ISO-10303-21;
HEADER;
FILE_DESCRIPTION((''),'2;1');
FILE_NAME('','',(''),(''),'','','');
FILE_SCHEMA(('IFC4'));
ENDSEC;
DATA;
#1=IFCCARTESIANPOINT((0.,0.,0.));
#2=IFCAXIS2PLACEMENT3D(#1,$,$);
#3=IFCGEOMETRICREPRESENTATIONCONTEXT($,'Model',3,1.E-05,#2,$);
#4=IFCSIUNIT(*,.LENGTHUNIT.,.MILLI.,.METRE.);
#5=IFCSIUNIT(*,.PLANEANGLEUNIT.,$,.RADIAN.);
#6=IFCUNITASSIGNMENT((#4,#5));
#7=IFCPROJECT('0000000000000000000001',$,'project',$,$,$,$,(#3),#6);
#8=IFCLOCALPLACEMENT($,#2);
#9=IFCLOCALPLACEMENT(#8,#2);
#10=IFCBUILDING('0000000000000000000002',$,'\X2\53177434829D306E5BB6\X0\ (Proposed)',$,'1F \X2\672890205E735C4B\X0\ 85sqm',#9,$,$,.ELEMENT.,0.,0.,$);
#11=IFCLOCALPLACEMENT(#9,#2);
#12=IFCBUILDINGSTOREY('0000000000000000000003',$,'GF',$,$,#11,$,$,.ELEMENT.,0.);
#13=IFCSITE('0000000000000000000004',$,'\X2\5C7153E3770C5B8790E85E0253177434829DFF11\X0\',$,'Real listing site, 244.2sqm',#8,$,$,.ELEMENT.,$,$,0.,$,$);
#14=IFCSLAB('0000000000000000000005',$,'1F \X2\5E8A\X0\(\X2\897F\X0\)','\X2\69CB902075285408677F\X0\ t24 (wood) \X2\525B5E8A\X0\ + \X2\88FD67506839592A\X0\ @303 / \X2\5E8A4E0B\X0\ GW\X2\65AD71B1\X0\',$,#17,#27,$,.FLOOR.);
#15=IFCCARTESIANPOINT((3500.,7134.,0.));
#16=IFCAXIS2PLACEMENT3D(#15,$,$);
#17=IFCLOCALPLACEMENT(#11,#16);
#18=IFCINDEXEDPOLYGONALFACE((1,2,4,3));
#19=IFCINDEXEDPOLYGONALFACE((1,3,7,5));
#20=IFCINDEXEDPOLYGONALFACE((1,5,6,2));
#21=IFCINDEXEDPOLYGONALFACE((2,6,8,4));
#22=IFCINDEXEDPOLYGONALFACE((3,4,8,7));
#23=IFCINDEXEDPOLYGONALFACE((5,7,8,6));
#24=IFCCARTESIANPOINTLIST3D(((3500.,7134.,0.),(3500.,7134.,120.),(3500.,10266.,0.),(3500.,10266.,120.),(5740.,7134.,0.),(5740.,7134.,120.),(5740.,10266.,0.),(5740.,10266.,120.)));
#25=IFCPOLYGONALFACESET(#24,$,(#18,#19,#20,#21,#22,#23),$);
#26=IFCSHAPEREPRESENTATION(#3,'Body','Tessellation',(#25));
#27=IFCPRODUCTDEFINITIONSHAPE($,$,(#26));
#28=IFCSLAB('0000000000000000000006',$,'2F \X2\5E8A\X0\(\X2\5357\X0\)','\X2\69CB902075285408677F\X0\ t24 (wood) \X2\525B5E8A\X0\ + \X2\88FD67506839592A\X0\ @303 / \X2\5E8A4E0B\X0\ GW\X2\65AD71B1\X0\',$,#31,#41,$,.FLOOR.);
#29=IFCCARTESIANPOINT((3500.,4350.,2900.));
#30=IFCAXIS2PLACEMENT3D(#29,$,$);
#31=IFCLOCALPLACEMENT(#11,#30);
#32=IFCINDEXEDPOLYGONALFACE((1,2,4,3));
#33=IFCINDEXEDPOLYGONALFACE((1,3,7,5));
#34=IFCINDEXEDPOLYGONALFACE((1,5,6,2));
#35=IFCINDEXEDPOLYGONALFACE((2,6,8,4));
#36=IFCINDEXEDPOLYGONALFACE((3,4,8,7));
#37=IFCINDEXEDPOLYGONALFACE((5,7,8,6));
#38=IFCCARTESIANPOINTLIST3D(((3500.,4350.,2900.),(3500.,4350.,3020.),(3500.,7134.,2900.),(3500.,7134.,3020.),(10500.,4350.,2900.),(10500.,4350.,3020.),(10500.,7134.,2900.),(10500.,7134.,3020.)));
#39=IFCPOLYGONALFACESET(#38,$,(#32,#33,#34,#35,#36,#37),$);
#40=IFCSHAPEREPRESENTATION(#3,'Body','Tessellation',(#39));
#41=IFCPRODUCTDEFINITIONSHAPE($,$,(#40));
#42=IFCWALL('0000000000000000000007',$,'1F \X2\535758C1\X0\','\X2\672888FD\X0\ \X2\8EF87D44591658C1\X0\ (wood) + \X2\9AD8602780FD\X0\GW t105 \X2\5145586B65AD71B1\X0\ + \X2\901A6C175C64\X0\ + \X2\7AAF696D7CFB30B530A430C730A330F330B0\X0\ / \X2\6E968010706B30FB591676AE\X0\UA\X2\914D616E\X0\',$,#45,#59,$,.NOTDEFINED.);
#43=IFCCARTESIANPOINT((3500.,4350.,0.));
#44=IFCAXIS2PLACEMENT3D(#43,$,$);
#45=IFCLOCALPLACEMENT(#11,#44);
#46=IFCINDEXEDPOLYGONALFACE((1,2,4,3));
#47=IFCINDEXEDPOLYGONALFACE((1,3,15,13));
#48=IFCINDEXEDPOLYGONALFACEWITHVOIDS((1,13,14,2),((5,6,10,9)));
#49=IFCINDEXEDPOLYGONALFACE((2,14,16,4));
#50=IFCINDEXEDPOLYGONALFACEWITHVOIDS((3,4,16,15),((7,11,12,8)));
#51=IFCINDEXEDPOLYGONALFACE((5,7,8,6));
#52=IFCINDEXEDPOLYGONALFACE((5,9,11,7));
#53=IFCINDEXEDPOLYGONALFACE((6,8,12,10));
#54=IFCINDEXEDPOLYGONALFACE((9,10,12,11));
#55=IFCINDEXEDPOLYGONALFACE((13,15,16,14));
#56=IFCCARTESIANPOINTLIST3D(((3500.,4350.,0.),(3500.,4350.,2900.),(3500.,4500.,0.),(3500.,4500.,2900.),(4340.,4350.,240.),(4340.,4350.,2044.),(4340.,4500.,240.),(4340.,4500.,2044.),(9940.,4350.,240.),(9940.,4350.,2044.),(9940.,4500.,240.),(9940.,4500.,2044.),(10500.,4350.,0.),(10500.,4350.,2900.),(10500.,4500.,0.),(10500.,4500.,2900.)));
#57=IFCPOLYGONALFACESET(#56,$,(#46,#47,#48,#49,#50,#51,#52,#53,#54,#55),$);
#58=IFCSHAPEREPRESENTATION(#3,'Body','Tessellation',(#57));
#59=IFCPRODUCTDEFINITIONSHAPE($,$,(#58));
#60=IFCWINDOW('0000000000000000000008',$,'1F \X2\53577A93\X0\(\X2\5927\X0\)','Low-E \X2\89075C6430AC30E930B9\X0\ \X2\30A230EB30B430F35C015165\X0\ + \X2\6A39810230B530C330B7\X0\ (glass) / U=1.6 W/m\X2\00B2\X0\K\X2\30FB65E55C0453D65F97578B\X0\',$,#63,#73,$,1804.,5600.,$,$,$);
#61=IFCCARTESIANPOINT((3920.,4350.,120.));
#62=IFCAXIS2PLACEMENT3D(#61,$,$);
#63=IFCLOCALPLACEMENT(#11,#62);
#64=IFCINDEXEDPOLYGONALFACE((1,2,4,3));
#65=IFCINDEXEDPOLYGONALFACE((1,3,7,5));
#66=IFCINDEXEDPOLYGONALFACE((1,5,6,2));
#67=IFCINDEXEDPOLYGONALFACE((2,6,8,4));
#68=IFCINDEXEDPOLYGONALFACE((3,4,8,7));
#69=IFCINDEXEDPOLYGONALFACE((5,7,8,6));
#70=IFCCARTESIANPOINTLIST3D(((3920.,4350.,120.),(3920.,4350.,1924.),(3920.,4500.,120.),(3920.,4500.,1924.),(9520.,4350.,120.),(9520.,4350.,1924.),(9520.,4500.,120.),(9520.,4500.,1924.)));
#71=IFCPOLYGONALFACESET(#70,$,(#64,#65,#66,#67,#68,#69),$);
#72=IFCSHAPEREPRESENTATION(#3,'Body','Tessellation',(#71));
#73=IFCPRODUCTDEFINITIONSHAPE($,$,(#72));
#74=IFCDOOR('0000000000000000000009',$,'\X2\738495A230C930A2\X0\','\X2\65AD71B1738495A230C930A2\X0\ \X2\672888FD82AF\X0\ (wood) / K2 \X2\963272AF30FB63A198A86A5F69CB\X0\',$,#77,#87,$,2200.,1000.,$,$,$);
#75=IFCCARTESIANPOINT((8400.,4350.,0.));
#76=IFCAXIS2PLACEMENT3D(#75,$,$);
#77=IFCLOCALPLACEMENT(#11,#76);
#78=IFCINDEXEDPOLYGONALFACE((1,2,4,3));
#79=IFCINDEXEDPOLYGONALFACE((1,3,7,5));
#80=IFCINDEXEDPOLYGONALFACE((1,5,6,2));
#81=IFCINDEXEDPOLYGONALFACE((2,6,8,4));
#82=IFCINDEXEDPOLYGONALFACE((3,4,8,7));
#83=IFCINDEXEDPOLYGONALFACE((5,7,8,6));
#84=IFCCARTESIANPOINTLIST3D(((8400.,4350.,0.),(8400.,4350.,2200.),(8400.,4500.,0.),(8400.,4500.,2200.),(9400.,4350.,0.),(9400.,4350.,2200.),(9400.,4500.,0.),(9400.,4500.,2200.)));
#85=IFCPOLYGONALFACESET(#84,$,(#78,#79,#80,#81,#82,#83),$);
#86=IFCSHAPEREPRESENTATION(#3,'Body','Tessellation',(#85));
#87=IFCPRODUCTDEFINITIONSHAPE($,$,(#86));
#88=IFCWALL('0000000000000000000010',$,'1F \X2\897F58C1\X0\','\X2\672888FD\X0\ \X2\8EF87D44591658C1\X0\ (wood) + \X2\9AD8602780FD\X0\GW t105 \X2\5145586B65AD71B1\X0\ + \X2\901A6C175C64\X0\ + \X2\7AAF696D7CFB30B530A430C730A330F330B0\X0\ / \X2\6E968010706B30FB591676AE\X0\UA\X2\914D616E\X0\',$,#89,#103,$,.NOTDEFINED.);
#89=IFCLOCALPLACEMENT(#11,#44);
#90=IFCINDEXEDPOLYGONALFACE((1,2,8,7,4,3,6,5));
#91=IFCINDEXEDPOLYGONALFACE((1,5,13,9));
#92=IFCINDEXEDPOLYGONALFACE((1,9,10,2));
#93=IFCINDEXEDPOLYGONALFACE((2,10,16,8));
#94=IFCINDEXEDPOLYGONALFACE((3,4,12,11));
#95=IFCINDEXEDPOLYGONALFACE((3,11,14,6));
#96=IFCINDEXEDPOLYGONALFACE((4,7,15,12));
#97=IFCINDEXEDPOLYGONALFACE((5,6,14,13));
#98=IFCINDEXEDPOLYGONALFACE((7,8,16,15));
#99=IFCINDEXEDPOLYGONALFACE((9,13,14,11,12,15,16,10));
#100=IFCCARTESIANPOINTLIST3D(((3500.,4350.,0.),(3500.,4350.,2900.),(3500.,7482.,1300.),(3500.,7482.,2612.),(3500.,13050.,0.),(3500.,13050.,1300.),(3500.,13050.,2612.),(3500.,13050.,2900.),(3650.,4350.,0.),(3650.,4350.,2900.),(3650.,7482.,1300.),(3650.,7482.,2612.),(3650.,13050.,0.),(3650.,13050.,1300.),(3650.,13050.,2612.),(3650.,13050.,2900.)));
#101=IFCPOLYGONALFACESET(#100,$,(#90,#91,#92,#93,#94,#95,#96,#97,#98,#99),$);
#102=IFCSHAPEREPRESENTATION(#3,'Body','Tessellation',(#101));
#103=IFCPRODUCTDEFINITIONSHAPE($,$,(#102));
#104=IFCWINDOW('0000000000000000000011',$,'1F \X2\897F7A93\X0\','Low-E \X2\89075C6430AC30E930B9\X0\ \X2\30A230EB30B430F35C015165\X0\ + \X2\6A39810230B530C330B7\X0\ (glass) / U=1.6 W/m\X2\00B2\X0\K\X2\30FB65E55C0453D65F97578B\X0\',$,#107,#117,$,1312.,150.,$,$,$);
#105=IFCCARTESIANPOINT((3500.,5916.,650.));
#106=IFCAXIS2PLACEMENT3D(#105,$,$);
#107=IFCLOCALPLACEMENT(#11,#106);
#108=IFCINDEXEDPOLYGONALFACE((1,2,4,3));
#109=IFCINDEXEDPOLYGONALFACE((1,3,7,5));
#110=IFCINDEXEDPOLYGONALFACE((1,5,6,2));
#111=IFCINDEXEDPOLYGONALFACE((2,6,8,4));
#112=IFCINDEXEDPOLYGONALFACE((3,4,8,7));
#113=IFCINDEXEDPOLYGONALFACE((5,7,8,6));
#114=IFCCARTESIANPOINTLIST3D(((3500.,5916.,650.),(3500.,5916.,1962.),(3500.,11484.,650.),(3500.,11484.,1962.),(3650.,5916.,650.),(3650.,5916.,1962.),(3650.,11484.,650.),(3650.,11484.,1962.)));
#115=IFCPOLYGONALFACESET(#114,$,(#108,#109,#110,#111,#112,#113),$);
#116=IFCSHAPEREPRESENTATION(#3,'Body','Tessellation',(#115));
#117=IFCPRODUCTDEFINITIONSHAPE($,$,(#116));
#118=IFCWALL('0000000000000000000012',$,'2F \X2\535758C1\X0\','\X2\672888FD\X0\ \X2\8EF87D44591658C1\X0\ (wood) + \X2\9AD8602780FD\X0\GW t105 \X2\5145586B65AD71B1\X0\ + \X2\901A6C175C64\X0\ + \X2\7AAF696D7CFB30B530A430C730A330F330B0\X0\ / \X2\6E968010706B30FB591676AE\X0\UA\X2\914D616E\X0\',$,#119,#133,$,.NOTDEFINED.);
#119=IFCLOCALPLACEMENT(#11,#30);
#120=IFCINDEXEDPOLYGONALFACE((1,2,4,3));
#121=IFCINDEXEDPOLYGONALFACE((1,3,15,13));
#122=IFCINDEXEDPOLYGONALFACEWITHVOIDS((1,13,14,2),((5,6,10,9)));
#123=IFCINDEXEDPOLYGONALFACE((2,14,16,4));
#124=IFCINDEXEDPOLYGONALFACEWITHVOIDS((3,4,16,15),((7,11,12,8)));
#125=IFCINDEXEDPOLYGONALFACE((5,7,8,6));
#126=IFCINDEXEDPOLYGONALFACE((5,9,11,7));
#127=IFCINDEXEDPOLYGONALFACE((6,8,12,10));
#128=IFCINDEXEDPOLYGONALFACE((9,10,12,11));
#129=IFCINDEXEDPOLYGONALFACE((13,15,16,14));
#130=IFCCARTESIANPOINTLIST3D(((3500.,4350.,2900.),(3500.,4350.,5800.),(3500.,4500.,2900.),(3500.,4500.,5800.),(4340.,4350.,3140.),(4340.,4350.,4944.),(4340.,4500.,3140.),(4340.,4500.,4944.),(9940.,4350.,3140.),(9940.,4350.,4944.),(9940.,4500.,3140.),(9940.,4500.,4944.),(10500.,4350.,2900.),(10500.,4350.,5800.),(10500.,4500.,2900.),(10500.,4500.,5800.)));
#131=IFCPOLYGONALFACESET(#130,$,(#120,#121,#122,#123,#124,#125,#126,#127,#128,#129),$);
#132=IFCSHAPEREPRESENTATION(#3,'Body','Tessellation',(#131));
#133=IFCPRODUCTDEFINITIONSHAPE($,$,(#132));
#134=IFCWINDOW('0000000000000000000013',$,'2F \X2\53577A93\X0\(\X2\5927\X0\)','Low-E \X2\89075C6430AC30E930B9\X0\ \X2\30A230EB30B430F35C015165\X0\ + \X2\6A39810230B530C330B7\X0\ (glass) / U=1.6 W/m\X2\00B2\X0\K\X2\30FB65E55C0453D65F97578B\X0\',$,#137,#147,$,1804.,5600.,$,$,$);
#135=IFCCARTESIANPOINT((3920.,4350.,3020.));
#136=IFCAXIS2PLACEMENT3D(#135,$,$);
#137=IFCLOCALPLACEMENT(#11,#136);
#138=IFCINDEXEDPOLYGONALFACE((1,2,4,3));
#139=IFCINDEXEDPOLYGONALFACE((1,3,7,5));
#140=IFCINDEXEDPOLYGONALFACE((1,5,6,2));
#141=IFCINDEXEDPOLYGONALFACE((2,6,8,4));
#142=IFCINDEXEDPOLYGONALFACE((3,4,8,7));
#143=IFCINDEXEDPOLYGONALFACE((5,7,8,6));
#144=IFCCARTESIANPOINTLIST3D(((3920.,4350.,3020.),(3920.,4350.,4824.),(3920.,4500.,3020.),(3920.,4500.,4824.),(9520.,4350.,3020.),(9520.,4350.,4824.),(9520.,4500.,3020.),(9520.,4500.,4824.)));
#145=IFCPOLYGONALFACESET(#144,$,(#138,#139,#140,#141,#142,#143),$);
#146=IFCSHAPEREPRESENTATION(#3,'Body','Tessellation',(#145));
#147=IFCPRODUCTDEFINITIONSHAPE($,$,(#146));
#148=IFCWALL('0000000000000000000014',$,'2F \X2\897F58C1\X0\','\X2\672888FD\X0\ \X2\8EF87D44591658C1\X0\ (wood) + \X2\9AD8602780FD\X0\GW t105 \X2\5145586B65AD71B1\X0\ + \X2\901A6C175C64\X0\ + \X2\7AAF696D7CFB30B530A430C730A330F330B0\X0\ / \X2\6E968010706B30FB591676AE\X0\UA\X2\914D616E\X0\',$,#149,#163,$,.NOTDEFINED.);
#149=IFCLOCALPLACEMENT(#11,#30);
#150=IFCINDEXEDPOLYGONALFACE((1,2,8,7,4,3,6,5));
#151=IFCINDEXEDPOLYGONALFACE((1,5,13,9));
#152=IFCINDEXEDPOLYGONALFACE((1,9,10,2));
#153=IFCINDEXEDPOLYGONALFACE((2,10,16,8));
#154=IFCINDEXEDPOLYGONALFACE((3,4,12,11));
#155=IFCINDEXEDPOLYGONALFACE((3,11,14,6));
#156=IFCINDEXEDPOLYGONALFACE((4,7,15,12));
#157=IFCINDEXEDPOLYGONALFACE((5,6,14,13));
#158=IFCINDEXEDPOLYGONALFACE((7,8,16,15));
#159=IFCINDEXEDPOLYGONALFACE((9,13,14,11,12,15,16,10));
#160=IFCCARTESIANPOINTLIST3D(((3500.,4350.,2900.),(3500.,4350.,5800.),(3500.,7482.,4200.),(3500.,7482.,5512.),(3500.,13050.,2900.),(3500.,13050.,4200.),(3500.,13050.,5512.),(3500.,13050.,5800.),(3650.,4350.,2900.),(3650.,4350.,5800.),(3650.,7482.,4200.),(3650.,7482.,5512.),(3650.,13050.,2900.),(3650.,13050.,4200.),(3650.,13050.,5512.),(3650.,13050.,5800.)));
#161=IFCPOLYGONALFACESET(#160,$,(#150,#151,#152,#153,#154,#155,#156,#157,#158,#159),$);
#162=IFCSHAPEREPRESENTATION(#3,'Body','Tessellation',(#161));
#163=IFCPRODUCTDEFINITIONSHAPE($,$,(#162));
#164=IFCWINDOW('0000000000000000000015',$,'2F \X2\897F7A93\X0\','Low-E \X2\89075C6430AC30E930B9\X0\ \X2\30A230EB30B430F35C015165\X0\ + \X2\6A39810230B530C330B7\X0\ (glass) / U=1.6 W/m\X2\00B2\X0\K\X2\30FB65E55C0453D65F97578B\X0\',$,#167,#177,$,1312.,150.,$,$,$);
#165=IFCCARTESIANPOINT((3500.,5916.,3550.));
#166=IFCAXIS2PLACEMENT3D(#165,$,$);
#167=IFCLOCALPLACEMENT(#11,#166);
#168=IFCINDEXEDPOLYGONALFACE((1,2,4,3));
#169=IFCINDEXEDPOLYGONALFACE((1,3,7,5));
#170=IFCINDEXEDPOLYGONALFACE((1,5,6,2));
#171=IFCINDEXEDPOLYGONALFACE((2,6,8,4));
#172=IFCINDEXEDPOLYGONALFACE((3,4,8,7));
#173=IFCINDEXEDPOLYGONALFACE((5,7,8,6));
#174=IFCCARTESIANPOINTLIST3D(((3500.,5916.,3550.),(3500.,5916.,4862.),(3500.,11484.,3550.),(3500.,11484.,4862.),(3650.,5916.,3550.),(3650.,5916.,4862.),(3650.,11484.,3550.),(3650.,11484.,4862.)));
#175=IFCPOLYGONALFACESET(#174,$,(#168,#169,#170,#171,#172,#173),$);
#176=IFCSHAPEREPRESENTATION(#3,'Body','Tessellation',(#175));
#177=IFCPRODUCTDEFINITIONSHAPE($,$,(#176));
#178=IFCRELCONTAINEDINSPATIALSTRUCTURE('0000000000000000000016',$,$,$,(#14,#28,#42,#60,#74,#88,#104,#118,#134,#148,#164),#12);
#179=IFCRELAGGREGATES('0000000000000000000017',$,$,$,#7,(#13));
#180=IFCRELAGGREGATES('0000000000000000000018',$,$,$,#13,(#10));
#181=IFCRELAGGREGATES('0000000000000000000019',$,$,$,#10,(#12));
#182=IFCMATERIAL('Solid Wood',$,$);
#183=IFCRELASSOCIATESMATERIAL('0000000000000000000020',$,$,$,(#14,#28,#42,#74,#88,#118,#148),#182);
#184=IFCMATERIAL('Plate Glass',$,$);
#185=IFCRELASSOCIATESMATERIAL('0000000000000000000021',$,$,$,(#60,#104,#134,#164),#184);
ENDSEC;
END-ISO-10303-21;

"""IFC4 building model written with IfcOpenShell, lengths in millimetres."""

from ifc_helpers import new_model, si_unit, frame, frame_2d, origin, place, context, project, spatial, rectangle, extrude, material, element, fill, save


model = new_model("IFC4")

# Units and contexts
model_context = context("Model", 3, precision=1e-05, world=origin())
ifc_project = project(units=[si_unit("LENGTHUNIT", "METRE", prefix="MILLI"), si_unit("PLANEANGLEUNIT", "RADIAN")], contexts=[model_context])

# Site, building, storey
site_placement = place(None, origin())
site = spatial("IfcSite", under=ifc_project, at=site_placement, Name="山口県宇部市北琴芝１", ObjectType="Real listing site, 244.2sqm", CompositionType="ELEMENT", RefElevation=0.0)
building_placement = place(site_placement, origin())
building = spatial("IfcBuilding", under=site, at=building_placement, Name="北琴芝の家 (Proposed)", ObjectType="1F 木造平屋 85sqm", CompositionType="ELEMENT", ElevationOfRefHeight=0.0, ElevationOfTerrain=0.0)
storey_placement = place(building_placement, origin())
storey = spatial("IfcBuildingStorey", under=building, at=storey_placement, Name="GF", CompositionType="ELEMENT", Elevation=0.0)

# Slabs
ifc_material_1 = material(Name="Solid Wood")
slab_1_placement = place(storey_placement, frame((3500.0, 7134.0, 0.0)))
element("IfcSlab", 1, at=slab_1_placement, inside=storey, material=ifc_material_1, Name="1F 床(西)", Description="構造用合板 t24 (wood) 剛床 + 製材根太 @303 / 床下 GW断熱", PredefinedType="FLOOR", context=model_context, shape_type="SweptSolid", body=[
    extrude(rectangle(XDim=2240.0, YDim=3132.0, at=frame_2d((1120.0, 1566.0))), frame((3500.0, 7134.0, 0.0)), (0.0, 0.0, 1.0), 120.0),
])
slab_2_placement = place(storey_placement, frame((3500.0, 4350.0, 2900.0)))
element("IfcSlab", 2, at=slab_2_placement, inside=storey, material=ifc_material_1, Name="2F 床(南)", Description="構造用合板 t24 (wood) 剛床 + 製材根太 @303 / 床下 GW断熱", PredefinedType="FLOOR", context=model_context, shape_type="SweptSolid", body=[
    extrude(rectangle(XDim=7000.0, YDim=2784.0, at=frame_2d((3500.0, 1392.0))), frame((3500.0, 4350.0, 2900.0)), (0.0, 0.0, 1.0), 120.0),
])

# Wall, openings, window, door
wall_1_placement = place(storey_placement, frame((3500.0, 4350.0, 0.0)))
wall_1 = element("IfcWall", 3, at=wall_1_placement, inside=storey, material=ifc_material_1, Name="1F 南壁", Description="木製 軸組外壁 (wood) + 高性能GW t105 充填断熱 + 通気層 + 窯業系サイディング / 準耐火・外皮UA配慮", PredefinedType="NOTDEFINED", context=model_context, shape_type="SweptSolid", body=[
    extrude(rectangle(XDim=7000.0, YDim=150.0, at=frame_2d((3500.0, 75.0))), frame((3500.0, 4350.0, 0.0)), (0.0, 0.0, 1.0), 2900.0),
])
opening_1_placement = place(storey_placement, frame((3920.0, 4350.0, 120.0)))
opening_1 = element("IfcOpeningElement", 4, at=opening_1_placement, cuts=wall_1, PredefinedType="NOTDEFINED", context=model_context, shape_type="SweptSolid", body=[
    extrude(rectangle(XDim=5600.0, YDim=150.0, at=frame_2d((2800.0, 75.0))), frame((3920.0, 4350.0, 120.0)), (0.0, 0.0, 1.0), 1804.0),
])
opening_2_placement = place(storey_placement, frame((8400.0, 4350.0, 0.0)))
opening_2 = element("IfcOpeningElement", 5, at=opening_2_placement, cuts=wall_1, PredefinedType="NOTDEFINED", context=model_context, shape_type="SweptSolid", body=[
    extrude(rectangle(XDim=1000.0, YDim=150.0, at=frame_2d((500.0, 75.0))), frame((8400.0, 4350.0, 0.0)), (0.0, 0.0, 1.0), 2200.0),
])
ifc_material_2 = material(Name="Plate Glass")
window_1_placement = place(storey_placement, frame((3920.0, 4350.0, 120.0)))
window_1 = element("IfcWindow", 6, at=window_1_placement, inside=storey, material=ifc_material_2, Name="1F 南窓(大)", Description="Low-E 複層ガラス アルゴン封入 + 樹脂サッシ (glass) / U=1.6 W/m²K・日射取得型", OverallHeight=1804.0, OverallWidth=5600.0, context=model_context, shape_type="SweptSolid", body=[
    extrude(rectangle(XDim=5600.0, YDim=150.0, at=frame_2d((2800.0, 75.0))), frame((3920.0, 4350.0, 120.0)), (0.0, 0.0, 1.0), 1804.0),
])
fill(opening_1, window_1)
door_placement = place(storey_placement, frame((8400.0, 4350.0, 0.0)))
door = element("IfcDoor", 7, at=door_placement, inside=storey, material=ifc_material_1, Name="玄関ドア", Description="断熱玄関ドア 木製芯 (wood) / K2 防犯・採風機構", OverallHeight=2200.0, OverallWidth=1000.0, context=model_context, shape_type="SweptSolid", body=[
    extrude(rectangle(XDim=1000.0, YDim=150.0, at=frame_2d((500.0, 75.0))), frame((8400.0, 4350.0, 0.0)), (0.0, 0.0, 1.0), 2200.0),
])
fill(opening_2, door)

# Walls, openings, windows
wall_2_placement = place(storey_placement, frame((3500.0, 4350.0, 0.0)))
wall_2 = element("IfcWall", 8, at=wall_2_placement, inside=storey, material=ifc_material_1, Name="1F 西壁", Description="木製 軸組外壁 (wood) + 高性能GW t105 充填断熱 + 通気層 + 窯業系サイディング / 準耐火・外皮UA配慮", PredefinedType="NOTDEFINED", context=model_context, shape_type="SweptSolid", body=[
    extrude(rectangle(XDim=150.0, YDim=8700.0, at=frame_2d((75.0, 4350.0))), frame((3500.0, 4350.0, 0.0)), (0.0, 0.0, 1.0), 2900.0),
])
opening_3_placement = place(storey_placement, frame((3500.0, 5916.0, 650.0)))
opening_3 = element("IfcOpeningElement", 9, at=opening_3_placement, cuts=wall_2, PredefinedType="NOTDEFINED", context=model_context, shape_type="SweptSolid", body=[
    extrude(rectangle(XDim=150.0, YDim=5568.0, at=frame_2d((75.0, 2784.0))), frame((3500.0, 5916.0, 650.0)), (0.0, 0.0, 1.0), 1312.0),
])
window_2_placement = place(storey_placement, frame((3500.0, 5916.0, 650.0)))
window_2 = element("IfcWindow", 10, at=window_2_placement, inside=storey, material=ifc_material_2, Name="1F 西窓", Description="Low-E 複層ガラス アルゴン封入 + 樹脂サッシ (glass) / U=1.6 W/m²K・日射取得型", OverallHeight=1312.0, OverallWidth=150.0, context=model_context, shape_type="SweptSolid", body=[
    extrude(rectangle(XDim=150.0, YDim=5568.0, at=frame_2d((75.0, 2784.0))), frame((3500.0, 5916.0, 650.0)), (0.0, 0.0, 1.0), 1312.0),
])
fill(opening_3, window_2)
wall_3_placement = place(storey_placement, frame((3500.0, 4350.0, 2900.0)))
wall_3 = element("IfcWall", 11, at=wall_3_placement, inside=storey, material=ifc_material_1, Name="2F 南壁", Description="木製 軸組外壁 (wood) + 高性能GW t105 充填断熱 + 通気層 + 窯業系サイディング / 準耐火・外皮UA配慮", PredefinedType="NOTDEFINED", context=model_context, shape_type="SweptSolid", body=[
    extrude(rectangle(XDim=7000.0, YDim=150.0, at=frame_2d((3500.0, 75.0))), frame((3500.0, 4350.0, 2900.0)), (0.0, 0.0, 1.0), 2900.0),
])
opening_4_placement = place(storey_placement, frame((3920.0, 4350.0, 3020.0)))
opening_4 = element("IfcOpeningElement", 12, at=opening_4_placement, cuts=wall_3, PredefinedType="NOTDEFINED", context=model_context, shape_type="SweptSolid", body=[
    extrude(rectangle(XDim=5600.0, YDim=150.0, at=frame_2d((2800.0, 75.0))), frame((3920.0, 4350.0, 3020.0)), (0.0, 0.0, 1.0), 1804.0),
])
window_3_placement = place(storey_placement, frame((3920.0, 4350.0, 3020.0)))
window_3 = element("IfcWindow", 13, at=window_3_placement, inside=storey, material=ifc_material_2, Name="2F 南窓(大)", Description="Low-E 複層ガラス アルゴン封入 + 樹脂サッシ (glass) / U=1.6 W/m²K・日射取得型", OverallHeight=1804.0, OverallWidth=5600.0, context=model_context, shape_type="SweptSolid", body=[
    extrude(rectangle(XDim=5600.0, YDim=150.0, at=frame_2d((2800.0, 75.0))), frame((3920.0, 4350.0, 3020.0)), (0.0, 0.0, 1.0), 1804.0),
])
fill(opening_4, window_3)
wall_4_placement = place(storey_placement, frame((3500.0, 4350.0, 2900.0)))
wall_4 = element("IfcWall", 14, at=wall_4_placement, inside=storey, material=ifc_material_1, Name="2F 西壁", Description="木製 軸組外壁 (wood) + 高性能GW t105 充填断熱 + 通気層 + 窯業系サイディング / 準耐火・外皮UA配慮", PredefinedType="NOTDEFINED", context=model_context, shape_type="SweptSolid", body=[
    extrude(rectangle(XDim=150.0, YDim=8700.0, at=frame_2d((75.0, 4350.0))), frame((3500.0, 4350.0, 2900.0)), (0.0, 0.0, 1.0), 2900.0),
])
opening_5_placement = place(storey_placement, frame((3500.0, 5916.0, 3550.0)))
opening_5 = element("IfcOpeningElement", 15, at=opening_5_placement, cuts=wall_4, PredefinedType="NOTDEFINED", context=model_context, shape_type="SweptSolid", body=[
    extrude(rectangle(XDim=150.0, YDim=5568.0, at=frame_2d((75.0, 2784.0))), frame((3500.0, 5916.0, 3550.0)), (0.0, 0.0, 1.0), 1312.0),
])
window_4_placement = place(storey_placement, frame((3500.0, 5916.0, 3550.0)))
window_4 = element("IfcWindow", 16, at=window_4_placement, inside=storey, material=ifc_material_2, Name="2F 西窓", Description="Low-E 複層ガラス アルゴン封入 + 樹脂サッシ (glass) / U=1.6 W/m²K・日射取得型", OverallHeight=1312.0, OverallWidth=150.0, context=model_context, shape_type="SweptSolid", body=[
    extrude(rectangle(XDim=150.0, YDim=5568.0, at=frame_2d((75.0, 2784.0))), frame((3500.0, 5916.0, 3550.0)), (0.0, 0.0, 1.0), 1312.0),
])
fill(opening_5, window_4)

save(model, "model.ifc")
